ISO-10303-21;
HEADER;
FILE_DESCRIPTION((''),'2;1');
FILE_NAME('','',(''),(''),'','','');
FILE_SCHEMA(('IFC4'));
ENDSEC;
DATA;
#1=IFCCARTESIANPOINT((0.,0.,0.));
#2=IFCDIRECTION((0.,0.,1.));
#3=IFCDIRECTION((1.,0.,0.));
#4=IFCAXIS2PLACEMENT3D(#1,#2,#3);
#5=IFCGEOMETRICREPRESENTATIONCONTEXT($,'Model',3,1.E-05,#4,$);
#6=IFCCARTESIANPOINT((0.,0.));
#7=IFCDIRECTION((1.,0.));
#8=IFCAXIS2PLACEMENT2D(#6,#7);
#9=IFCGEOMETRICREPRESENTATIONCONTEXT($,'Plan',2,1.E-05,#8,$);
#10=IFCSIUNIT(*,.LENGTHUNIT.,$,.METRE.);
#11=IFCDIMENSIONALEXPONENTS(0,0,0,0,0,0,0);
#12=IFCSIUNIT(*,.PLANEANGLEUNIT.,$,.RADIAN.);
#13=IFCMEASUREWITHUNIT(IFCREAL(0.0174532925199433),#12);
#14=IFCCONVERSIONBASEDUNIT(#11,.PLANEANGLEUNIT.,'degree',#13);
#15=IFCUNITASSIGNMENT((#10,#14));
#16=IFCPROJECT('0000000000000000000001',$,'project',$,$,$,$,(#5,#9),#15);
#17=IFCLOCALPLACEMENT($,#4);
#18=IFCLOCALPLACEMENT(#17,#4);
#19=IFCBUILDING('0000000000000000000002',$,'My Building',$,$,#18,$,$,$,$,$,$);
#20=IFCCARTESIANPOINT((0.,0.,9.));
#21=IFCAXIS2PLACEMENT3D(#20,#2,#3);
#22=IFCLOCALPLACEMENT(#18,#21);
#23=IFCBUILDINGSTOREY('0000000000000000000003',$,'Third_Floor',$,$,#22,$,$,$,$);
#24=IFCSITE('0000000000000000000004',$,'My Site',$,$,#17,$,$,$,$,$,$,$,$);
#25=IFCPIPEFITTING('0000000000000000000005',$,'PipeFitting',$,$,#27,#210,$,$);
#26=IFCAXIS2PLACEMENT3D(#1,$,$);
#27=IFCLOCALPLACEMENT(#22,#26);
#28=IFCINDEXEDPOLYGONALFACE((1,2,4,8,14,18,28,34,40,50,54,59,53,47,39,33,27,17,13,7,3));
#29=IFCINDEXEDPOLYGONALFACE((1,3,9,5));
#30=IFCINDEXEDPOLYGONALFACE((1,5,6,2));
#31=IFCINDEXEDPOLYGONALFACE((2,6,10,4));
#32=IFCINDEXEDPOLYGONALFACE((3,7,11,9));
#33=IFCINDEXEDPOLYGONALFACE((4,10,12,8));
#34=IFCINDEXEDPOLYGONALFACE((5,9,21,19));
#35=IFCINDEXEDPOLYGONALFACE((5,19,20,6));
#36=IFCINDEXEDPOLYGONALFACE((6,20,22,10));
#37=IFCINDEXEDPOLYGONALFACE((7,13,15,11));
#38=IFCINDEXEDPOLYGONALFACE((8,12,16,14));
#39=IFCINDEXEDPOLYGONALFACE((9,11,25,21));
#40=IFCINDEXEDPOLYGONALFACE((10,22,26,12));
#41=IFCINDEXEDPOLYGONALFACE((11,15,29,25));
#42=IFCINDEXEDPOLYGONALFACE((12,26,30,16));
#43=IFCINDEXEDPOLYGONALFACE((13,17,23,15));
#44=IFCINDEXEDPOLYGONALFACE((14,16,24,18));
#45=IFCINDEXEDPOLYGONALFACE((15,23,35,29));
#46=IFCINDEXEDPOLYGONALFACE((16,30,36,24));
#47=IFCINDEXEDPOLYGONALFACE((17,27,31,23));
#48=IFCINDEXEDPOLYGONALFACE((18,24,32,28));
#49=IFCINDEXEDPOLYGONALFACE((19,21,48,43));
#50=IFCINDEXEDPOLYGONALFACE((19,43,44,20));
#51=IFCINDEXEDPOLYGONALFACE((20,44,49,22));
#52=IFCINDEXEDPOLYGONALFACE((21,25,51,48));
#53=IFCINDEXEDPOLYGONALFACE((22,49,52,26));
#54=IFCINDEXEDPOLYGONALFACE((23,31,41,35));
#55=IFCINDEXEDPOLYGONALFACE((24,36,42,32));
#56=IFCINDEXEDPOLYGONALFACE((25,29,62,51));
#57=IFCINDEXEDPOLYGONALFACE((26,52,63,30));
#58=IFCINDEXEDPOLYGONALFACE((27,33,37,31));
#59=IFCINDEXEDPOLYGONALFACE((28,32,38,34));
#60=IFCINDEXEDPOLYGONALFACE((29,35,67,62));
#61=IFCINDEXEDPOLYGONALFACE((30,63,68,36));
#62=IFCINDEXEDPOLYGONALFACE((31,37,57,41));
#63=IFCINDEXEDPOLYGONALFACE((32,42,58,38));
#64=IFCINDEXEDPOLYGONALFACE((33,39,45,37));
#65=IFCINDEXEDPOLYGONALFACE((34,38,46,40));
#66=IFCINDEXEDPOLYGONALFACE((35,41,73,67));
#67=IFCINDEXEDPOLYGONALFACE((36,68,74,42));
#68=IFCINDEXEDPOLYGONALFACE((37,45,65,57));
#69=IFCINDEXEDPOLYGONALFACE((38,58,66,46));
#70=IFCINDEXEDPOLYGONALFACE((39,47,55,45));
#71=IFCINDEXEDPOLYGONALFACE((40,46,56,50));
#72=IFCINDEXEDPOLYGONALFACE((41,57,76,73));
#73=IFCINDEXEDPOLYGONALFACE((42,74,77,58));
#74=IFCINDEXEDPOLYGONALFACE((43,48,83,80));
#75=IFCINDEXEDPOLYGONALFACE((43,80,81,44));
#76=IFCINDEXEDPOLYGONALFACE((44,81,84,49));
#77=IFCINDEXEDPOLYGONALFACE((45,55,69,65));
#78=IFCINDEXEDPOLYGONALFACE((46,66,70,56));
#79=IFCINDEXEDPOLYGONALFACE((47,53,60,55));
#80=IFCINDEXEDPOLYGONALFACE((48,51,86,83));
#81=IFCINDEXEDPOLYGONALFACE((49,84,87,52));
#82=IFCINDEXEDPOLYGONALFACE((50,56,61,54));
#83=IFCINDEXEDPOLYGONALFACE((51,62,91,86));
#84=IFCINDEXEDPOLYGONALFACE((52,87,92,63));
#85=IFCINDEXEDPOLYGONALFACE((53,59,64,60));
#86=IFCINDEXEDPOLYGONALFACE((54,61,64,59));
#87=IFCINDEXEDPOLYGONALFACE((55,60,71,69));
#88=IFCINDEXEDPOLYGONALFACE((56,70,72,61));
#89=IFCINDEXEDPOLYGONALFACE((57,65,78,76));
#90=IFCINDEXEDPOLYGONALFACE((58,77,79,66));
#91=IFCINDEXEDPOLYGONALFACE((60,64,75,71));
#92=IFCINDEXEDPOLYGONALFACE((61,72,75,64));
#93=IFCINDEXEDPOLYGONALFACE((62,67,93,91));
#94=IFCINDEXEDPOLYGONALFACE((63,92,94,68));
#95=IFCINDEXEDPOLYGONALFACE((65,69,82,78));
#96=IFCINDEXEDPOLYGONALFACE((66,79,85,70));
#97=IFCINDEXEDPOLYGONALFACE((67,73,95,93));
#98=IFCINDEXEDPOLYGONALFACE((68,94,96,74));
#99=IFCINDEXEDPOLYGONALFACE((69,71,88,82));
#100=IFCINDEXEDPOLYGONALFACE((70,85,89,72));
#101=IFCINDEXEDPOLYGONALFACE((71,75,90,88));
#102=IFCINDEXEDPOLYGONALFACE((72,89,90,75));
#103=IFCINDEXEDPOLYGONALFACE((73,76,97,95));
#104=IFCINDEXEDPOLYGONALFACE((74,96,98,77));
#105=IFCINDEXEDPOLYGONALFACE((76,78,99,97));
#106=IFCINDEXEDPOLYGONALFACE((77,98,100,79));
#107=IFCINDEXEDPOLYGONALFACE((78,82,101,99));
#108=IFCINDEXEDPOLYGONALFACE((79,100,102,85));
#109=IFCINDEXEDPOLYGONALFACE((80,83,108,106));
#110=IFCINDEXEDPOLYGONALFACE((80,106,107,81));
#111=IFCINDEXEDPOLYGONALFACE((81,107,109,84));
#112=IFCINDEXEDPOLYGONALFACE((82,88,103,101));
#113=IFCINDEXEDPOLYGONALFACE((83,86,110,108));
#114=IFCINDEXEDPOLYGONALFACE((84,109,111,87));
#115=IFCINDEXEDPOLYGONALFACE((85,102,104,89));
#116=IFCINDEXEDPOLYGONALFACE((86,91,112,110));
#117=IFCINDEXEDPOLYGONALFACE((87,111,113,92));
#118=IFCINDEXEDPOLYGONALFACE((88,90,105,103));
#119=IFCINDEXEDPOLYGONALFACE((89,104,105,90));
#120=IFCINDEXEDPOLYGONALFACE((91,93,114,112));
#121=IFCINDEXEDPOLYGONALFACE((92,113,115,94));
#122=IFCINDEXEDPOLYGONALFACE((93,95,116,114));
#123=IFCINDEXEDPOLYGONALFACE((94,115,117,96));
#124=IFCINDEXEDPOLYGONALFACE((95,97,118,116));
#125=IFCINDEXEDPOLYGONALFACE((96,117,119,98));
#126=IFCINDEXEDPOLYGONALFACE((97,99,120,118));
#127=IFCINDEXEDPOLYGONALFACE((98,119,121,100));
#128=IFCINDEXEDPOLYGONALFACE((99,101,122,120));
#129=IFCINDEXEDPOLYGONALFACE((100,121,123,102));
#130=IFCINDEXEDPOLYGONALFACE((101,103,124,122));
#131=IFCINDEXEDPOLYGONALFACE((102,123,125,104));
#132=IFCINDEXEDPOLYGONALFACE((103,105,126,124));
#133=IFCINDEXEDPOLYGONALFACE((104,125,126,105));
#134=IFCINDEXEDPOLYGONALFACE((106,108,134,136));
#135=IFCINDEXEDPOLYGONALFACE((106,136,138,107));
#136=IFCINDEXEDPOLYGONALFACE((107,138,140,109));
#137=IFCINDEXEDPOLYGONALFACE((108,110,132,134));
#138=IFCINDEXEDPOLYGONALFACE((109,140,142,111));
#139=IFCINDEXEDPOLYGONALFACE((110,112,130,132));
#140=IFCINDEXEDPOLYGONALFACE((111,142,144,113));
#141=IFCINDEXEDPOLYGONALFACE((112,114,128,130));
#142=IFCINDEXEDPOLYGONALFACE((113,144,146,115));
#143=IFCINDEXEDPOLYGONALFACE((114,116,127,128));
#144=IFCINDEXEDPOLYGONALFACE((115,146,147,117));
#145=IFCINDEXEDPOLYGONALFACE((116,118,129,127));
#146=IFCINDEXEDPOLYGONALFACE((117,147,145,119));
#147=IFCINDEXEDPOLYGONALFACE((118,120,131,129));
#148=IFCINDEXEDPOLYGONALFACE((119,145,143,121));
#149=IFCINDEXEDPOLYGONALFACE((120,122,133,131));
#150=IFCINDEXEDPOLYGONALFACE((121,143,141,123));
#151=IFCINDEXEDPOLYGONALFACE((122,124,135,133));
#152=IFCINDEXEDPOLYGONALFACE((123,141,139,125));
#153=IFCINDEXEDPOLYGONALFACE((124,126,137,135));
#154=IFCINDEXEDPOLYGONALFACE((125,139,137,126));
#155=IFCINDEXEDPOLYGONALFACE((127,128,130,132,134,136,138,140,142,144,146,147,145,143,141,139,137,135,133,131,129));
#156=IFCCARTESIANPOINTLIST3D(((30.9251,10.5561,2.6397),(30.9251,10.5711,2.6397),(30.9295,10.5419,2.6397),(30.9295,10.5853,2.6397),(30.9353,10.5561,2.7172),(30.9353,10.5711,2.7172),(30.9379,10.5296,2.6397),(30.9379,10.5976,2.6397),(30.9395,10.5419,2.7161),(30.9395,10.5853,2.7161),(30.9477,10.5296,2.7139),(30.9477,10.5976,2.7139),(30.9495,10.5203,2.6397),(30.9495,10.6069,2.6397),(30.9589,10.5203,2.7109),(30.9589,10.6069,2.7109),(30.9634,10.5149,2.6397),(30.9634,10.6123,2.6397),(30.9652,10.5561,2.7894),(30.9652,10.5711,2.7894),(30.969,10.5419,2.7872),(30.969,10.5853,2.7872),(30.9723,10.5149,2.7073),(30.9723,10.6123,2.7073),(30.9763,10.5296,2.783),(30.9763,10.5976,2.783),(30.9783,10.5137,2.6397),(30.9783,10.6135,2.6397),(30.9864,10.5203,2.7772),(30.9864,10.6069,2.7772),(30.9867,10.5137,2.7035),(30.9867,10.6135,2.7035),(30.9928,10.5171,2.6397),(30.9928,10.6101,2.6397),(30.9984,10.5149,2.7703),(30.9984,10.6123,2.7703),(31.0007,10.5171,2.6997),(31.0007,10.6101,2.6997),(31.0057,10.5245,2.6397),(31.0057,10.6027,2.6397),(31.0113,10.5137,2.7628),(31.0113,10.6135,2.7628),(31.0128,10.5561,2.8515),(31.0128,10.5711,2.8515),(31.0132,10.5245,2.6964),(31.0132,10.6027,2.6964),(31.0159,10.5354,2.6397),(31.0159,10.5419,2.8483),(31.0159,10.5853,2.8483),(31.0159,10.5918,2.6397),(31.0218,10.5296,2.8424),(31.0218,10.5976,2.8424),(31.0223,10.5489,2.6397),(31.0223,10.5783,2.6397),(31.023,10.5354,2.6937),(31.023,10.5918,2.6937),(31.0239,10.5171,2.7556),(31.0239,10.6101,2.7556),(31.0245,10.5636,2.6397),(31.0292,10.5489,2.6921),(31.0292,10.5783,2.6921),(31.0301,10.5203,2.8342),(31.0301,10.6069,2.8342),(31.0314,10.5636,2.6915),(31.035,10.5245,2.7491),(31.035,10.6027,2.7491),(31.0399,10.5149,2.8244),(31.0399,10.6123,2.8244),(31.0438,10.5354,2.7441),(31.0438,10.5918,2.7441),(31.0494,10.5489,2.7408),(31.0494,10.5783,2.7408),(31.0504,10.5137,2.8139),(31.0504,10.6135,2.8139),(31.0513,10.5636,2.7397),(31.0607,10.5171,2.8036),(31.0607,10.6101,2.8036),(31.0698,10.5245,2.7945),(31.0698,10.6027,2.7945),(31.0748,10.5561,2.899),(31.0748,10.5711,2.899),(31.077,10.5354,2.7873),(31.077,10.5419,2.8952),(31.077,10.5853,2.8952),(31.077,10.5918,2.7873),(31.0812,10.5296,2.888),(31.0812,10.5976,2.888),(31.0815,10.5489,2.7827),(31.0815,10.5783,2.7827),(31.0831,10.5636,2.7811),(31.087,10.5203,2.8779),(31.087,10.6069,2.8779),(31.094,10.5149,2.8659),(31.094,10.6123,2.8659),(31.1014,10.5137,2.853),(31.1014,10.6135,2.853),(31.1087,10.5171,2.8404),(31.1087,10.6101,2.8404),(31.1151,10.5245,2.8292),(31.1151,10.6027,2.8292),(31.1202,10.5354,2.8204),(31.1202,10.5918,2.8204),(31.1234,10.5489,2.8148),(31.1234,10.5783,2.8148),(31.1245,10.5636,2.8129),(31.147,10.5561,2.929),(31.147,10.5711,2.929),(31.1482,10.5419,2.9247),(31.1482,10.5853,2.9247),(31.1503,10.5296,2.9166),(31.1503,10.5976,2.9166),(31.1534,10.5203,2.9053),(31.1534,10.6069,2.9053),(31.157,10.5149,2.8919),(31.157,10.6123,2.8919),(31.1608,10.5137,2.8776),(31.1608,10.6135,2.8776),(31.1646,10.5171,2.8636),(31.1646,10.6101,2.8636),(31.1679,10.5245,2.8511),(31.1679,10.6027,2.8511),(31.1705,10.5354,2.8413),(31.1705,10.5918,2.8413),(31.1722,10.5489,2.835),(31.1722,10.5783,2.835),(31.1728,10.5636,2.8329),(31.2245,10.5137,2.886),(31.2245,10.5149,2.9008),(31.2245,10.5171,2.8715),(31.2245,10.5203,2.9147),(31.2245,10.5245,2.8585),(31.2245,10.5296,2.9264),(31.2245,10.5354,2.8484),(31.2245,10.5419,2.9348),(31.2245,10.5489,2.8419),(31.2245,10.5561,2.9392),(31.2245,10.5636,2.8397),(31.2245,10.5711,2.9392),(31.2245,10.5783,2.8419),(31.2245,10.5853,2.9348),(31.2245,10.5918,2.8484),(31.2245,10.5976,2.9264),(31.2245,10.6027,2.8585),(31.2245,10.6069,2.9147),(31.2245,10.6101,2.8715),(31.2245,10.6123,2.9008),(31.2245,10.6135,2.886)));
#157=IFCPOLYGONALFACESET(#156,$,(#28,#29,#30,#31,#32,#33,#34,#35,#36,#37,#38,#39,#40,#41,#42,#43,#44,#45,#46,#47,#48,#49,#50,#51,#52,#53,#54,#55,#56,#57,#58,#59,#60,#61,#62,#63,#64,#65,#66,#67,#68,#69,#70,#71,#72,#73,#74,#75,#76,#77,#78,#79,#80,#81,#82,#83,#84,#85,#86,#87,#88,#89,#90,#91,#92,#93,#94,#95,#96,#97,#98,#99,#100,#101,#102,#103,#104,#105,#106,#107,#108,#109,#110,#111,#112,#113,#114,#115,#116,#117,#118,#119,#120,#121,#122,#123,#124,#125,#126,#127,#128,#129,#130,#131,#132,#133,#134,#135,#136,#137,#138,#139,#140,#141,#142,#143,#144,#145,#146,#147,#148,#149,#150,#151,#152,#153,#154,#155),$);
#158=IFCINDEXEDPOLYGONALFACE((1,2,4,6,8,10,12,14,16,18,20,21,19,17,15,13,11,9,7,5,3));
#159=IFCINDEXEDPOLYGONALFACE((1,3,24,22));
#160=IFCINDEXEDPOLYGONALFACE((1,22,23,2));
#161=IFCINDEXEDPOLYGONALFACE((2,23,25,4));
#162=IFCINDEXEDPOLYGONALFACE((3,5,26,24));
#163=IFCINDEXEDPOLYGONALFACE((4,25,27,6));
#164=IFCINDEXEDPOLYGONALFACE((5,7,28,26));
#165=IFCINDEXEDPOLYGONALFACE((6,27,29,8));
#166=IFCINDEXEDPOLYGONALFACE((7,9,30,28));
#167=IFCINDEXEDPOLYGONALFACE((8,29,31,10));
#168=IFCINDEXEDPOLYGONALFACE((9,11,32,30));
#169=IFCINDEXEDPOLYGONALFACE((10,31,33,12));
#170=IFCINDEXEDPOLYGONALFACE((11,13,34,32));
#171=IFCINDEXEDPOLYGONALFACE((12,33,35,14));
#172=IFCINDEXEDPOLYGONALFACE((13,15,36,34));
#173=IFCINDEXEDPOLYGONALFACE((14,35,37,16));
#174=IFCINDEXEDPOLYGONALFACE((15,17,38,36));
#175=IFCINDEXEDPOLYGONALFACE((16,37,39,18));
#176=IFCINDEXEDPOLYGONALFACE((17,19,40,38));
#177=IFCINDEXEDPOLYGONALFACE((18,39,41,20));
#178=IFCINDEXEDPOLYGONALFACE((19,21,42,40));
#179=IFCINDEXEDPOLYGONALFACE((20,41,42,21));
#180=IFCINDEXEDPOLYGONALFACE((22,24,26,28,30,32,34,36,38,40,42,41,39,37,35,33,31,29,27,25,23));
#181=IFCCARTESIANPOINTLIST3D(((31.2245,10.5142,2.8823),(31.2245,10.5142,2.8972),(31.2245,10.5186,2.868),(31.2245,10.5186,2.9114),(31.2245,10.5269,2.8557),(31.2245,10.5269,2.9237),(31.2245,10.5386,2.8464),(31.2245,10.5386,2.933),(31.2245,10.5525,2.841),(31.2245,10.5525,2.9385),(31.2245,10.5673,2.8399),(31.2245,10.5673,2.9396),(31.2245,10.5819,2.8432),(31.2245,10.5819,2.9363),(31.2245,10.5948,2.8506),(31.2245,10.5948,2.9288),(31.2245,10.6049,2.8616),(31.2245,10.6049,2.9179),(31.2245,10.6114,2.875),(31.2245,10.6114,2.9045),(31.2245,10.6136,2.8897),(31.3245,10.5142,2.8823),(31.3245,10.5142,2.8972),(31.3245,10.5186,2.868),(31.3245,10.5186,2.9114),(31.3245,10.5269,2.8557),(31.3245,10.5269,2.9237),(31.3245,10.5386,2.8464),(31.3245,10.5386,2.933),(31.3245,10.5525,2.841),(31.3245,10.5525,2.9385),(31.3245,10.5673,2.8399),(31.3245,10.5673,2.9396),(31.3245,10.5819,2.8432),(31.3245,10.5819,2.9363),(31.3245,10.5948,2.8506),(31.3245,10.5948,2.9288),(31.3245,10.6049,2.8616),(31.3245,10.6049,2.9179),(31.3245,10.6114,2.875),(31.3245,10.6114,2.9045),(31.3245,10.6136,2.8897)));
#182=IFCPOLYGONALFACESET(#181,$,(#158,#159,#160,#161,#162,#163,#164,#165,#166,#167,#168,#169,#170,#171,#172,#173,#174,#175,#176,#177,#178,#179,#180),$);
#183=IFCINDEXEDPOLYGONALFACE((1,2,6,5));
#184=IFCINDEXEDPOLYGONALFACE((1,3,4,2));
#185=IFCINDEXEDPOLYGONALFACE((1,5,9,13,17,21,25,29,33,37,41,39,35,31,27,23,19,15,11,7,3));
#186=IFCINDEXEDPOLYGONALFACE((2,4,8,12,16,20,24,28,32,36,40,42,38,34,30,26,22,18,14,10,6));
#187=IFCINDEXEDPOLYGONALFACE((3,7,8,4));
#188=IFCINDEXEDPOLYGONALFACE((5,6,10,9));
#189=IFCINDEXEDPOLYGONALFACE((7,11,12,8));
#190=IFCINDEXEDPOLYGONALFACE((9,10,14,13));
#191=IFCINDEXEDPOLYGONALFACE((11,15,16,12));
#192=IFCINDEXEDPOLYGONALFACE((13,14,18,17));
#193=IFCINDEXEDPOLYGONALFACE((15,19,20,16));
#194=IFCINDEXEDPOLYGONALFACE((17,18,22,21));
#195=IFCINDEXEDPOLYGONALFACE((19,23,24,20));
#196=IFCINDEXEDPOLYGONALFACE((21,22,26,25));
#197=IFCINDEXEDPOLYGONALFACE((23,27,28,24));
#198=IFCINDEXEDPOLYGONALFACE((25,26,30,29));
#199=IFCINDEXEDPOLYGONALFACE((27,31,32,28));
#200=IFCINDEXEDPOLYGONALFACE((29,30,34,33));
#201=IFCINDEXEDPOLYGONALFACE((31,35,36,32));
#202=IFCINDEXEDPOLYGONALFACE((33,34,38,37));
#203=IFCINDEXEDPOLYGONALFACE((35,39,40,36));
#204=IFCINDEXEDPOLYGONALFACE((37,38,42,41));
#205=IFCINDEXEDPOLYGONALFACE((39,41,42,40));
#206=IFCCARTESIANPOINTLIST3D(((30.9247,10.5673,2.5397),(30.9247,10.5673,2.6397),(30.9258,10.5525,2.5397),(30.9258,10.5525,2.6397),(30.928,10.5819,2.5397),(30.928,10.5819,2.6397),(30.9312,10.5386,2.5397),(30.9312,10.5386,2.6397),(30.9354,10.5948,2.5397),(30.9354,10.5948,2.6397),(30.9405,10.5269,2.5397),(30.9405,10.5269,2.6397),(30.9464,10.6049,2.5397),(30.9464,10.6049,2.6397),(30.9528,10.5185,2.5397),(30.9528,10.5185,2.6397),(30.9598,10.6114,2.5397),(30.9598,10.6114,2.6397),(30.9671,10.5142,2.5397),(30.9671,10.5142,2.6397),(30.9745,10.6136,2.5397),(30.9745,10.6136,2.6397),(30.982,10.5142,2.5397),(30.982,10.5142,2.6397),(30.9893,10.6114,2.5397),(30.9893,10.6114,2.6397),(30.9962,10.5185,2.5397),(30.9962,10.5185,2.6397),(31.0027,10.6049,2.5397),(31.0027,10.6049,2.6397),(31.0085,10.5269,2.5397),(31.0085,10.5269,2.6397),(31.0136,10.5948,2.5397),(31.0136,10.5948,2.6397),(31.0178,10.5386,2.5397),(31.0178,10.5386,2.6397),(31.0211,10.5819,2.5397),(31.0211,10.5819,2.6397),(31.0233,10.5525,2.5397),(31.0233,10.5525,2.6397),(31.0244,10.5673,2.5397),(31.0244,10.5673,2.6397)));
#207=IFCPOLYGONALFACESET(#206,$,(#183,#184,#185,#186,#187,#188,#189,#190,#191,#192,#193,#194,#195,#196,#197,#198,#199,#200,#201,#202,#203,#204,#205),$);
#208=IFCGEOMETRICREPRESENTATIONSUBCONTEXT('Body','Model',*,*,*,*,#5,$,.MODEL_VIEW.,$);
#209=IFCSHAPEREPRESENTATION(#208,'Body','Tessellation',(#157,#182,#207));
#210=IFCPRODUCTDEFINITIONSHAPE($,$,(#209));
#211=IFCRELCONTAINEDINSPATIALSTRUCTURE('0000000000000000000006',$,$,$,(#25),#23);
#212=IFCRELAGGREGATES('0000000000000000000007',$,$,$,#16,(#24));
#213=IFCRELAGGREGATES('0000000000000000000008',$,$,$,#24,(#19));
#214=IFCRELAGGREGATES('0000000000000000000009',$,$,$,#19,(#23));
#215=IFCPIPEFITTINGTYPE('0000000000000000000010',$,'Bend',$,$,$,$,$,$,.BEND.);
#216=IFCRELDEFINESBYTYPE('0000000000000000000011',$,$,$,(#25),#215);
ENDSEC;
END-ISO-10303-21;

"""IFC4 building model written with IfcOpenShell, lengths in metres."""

from ifc_helpers import new_model, entity, si_unit, converted_unit, frame, origin_with_axes, origin_2d_with_axis, place, context, subcontext, project, spatial, circle, extrude, source, transform, mapped, type_object, type_shapes, element, save


model = new_model("IFC4")

# Units and contexts
model_context = context("Model", 3, precision=1e-05, world=origin_with_axes())
plan_context = context("Plan", 2, precision=1e-05, world=origin_2d_with_axis())
body_context_1 = subcontext(model_context, "Body", "Model", "MODEL_VIEW")
ifc_project = project(units=[si_unit("LENGTHUNIT", "METRE"), converted_unit("PLANEANGLEUNIT", "degree", entity("IfcReal", 0.0174532925199433), si_unit("PLANEANGLEUNIT", "RADIAN"), dimensions=[0, 0, 0, 0, 0, 0, 0])], contexts=[model_context, plan_context])

# Site, building, storey
site_placement = place(None, origin_with_axes())
site = spatial("IfcSite", under=ifc_project, at=site_placement, Name="My Site")
building_placement = place(site_placement, origin_with_axes())
building = spatial("IfcBuilding", under=site, at=building_placement, Name="My Building")
storey_placement = place(building_placement, frame((0.0, 0.0, 9.0), z_axis=(0.0, 0.0, 1.0), x_axis=(1.0, 0.0, 0.0)))
storey = spatial("IfcBuildingStorey", under=building, at=storey_placement, Name="Third_Floor")

# Pipe fitting
pipe_fitting_type = type_object("IfcPipeFittingType", Name="Bend", PredefinedType="BEND")
shared_shape_1 = source(origin_with_axes(), body_context_1, "Body", "SolidModel", [
    entity("IfcSweptDiskSolid", entity("IfcIndexedPolyCurve", entity("IfcCartesianPointList3D", [[0.0, 0.0, -0.1], [0.0, -0.0732, -0.2768], [0.0, -0.25, -0.35]]), [entity("IfcArcIndex", [1, 2, 3])]), 0.05),
    extrude(circle(Radius=0.05), origin_with_axes(), (0.0, 0.0, -1.0), 0.1),
    extrude(circle(Radius=0.05), frame((0.0, -0.25, -0.35), z_axis=(0.0, -1.0, 0.0), x_axis=(1.0, 0.0, 0.0)), (0.0, 0.0, 1.0), 0.1),
])
type_shapes(pipe_fitting_type, [shared_shape_1])
for number, where, z_axis, x_axis, name in (
    (1, (31.3245, 10.5636, 2.8897), (1.0, 0.000001, 0.0), (-0.000001, 1.0, 0.0), "PipeFitting"),
):
    element("IfcPipeFitting", number, at=place(storey_placement, frame(where, z_axis=z_axis, x_axis=x_axis)), inside=storey, type_object=pipe_fitting_type, Name=name, context=body_context_1, shape_type="MappedRepresentation", body=[
        mapped(shared_shape_1, transform((0.0, 0.0, 0.0), x_axis=(1.0, 0.0, 0.0), y_axis=(0.0, 1.0, 0.0), z_axis=(0.0, 0.0, 1.0), scale=1.0)),
    ])

save(model, "model.ifc")
